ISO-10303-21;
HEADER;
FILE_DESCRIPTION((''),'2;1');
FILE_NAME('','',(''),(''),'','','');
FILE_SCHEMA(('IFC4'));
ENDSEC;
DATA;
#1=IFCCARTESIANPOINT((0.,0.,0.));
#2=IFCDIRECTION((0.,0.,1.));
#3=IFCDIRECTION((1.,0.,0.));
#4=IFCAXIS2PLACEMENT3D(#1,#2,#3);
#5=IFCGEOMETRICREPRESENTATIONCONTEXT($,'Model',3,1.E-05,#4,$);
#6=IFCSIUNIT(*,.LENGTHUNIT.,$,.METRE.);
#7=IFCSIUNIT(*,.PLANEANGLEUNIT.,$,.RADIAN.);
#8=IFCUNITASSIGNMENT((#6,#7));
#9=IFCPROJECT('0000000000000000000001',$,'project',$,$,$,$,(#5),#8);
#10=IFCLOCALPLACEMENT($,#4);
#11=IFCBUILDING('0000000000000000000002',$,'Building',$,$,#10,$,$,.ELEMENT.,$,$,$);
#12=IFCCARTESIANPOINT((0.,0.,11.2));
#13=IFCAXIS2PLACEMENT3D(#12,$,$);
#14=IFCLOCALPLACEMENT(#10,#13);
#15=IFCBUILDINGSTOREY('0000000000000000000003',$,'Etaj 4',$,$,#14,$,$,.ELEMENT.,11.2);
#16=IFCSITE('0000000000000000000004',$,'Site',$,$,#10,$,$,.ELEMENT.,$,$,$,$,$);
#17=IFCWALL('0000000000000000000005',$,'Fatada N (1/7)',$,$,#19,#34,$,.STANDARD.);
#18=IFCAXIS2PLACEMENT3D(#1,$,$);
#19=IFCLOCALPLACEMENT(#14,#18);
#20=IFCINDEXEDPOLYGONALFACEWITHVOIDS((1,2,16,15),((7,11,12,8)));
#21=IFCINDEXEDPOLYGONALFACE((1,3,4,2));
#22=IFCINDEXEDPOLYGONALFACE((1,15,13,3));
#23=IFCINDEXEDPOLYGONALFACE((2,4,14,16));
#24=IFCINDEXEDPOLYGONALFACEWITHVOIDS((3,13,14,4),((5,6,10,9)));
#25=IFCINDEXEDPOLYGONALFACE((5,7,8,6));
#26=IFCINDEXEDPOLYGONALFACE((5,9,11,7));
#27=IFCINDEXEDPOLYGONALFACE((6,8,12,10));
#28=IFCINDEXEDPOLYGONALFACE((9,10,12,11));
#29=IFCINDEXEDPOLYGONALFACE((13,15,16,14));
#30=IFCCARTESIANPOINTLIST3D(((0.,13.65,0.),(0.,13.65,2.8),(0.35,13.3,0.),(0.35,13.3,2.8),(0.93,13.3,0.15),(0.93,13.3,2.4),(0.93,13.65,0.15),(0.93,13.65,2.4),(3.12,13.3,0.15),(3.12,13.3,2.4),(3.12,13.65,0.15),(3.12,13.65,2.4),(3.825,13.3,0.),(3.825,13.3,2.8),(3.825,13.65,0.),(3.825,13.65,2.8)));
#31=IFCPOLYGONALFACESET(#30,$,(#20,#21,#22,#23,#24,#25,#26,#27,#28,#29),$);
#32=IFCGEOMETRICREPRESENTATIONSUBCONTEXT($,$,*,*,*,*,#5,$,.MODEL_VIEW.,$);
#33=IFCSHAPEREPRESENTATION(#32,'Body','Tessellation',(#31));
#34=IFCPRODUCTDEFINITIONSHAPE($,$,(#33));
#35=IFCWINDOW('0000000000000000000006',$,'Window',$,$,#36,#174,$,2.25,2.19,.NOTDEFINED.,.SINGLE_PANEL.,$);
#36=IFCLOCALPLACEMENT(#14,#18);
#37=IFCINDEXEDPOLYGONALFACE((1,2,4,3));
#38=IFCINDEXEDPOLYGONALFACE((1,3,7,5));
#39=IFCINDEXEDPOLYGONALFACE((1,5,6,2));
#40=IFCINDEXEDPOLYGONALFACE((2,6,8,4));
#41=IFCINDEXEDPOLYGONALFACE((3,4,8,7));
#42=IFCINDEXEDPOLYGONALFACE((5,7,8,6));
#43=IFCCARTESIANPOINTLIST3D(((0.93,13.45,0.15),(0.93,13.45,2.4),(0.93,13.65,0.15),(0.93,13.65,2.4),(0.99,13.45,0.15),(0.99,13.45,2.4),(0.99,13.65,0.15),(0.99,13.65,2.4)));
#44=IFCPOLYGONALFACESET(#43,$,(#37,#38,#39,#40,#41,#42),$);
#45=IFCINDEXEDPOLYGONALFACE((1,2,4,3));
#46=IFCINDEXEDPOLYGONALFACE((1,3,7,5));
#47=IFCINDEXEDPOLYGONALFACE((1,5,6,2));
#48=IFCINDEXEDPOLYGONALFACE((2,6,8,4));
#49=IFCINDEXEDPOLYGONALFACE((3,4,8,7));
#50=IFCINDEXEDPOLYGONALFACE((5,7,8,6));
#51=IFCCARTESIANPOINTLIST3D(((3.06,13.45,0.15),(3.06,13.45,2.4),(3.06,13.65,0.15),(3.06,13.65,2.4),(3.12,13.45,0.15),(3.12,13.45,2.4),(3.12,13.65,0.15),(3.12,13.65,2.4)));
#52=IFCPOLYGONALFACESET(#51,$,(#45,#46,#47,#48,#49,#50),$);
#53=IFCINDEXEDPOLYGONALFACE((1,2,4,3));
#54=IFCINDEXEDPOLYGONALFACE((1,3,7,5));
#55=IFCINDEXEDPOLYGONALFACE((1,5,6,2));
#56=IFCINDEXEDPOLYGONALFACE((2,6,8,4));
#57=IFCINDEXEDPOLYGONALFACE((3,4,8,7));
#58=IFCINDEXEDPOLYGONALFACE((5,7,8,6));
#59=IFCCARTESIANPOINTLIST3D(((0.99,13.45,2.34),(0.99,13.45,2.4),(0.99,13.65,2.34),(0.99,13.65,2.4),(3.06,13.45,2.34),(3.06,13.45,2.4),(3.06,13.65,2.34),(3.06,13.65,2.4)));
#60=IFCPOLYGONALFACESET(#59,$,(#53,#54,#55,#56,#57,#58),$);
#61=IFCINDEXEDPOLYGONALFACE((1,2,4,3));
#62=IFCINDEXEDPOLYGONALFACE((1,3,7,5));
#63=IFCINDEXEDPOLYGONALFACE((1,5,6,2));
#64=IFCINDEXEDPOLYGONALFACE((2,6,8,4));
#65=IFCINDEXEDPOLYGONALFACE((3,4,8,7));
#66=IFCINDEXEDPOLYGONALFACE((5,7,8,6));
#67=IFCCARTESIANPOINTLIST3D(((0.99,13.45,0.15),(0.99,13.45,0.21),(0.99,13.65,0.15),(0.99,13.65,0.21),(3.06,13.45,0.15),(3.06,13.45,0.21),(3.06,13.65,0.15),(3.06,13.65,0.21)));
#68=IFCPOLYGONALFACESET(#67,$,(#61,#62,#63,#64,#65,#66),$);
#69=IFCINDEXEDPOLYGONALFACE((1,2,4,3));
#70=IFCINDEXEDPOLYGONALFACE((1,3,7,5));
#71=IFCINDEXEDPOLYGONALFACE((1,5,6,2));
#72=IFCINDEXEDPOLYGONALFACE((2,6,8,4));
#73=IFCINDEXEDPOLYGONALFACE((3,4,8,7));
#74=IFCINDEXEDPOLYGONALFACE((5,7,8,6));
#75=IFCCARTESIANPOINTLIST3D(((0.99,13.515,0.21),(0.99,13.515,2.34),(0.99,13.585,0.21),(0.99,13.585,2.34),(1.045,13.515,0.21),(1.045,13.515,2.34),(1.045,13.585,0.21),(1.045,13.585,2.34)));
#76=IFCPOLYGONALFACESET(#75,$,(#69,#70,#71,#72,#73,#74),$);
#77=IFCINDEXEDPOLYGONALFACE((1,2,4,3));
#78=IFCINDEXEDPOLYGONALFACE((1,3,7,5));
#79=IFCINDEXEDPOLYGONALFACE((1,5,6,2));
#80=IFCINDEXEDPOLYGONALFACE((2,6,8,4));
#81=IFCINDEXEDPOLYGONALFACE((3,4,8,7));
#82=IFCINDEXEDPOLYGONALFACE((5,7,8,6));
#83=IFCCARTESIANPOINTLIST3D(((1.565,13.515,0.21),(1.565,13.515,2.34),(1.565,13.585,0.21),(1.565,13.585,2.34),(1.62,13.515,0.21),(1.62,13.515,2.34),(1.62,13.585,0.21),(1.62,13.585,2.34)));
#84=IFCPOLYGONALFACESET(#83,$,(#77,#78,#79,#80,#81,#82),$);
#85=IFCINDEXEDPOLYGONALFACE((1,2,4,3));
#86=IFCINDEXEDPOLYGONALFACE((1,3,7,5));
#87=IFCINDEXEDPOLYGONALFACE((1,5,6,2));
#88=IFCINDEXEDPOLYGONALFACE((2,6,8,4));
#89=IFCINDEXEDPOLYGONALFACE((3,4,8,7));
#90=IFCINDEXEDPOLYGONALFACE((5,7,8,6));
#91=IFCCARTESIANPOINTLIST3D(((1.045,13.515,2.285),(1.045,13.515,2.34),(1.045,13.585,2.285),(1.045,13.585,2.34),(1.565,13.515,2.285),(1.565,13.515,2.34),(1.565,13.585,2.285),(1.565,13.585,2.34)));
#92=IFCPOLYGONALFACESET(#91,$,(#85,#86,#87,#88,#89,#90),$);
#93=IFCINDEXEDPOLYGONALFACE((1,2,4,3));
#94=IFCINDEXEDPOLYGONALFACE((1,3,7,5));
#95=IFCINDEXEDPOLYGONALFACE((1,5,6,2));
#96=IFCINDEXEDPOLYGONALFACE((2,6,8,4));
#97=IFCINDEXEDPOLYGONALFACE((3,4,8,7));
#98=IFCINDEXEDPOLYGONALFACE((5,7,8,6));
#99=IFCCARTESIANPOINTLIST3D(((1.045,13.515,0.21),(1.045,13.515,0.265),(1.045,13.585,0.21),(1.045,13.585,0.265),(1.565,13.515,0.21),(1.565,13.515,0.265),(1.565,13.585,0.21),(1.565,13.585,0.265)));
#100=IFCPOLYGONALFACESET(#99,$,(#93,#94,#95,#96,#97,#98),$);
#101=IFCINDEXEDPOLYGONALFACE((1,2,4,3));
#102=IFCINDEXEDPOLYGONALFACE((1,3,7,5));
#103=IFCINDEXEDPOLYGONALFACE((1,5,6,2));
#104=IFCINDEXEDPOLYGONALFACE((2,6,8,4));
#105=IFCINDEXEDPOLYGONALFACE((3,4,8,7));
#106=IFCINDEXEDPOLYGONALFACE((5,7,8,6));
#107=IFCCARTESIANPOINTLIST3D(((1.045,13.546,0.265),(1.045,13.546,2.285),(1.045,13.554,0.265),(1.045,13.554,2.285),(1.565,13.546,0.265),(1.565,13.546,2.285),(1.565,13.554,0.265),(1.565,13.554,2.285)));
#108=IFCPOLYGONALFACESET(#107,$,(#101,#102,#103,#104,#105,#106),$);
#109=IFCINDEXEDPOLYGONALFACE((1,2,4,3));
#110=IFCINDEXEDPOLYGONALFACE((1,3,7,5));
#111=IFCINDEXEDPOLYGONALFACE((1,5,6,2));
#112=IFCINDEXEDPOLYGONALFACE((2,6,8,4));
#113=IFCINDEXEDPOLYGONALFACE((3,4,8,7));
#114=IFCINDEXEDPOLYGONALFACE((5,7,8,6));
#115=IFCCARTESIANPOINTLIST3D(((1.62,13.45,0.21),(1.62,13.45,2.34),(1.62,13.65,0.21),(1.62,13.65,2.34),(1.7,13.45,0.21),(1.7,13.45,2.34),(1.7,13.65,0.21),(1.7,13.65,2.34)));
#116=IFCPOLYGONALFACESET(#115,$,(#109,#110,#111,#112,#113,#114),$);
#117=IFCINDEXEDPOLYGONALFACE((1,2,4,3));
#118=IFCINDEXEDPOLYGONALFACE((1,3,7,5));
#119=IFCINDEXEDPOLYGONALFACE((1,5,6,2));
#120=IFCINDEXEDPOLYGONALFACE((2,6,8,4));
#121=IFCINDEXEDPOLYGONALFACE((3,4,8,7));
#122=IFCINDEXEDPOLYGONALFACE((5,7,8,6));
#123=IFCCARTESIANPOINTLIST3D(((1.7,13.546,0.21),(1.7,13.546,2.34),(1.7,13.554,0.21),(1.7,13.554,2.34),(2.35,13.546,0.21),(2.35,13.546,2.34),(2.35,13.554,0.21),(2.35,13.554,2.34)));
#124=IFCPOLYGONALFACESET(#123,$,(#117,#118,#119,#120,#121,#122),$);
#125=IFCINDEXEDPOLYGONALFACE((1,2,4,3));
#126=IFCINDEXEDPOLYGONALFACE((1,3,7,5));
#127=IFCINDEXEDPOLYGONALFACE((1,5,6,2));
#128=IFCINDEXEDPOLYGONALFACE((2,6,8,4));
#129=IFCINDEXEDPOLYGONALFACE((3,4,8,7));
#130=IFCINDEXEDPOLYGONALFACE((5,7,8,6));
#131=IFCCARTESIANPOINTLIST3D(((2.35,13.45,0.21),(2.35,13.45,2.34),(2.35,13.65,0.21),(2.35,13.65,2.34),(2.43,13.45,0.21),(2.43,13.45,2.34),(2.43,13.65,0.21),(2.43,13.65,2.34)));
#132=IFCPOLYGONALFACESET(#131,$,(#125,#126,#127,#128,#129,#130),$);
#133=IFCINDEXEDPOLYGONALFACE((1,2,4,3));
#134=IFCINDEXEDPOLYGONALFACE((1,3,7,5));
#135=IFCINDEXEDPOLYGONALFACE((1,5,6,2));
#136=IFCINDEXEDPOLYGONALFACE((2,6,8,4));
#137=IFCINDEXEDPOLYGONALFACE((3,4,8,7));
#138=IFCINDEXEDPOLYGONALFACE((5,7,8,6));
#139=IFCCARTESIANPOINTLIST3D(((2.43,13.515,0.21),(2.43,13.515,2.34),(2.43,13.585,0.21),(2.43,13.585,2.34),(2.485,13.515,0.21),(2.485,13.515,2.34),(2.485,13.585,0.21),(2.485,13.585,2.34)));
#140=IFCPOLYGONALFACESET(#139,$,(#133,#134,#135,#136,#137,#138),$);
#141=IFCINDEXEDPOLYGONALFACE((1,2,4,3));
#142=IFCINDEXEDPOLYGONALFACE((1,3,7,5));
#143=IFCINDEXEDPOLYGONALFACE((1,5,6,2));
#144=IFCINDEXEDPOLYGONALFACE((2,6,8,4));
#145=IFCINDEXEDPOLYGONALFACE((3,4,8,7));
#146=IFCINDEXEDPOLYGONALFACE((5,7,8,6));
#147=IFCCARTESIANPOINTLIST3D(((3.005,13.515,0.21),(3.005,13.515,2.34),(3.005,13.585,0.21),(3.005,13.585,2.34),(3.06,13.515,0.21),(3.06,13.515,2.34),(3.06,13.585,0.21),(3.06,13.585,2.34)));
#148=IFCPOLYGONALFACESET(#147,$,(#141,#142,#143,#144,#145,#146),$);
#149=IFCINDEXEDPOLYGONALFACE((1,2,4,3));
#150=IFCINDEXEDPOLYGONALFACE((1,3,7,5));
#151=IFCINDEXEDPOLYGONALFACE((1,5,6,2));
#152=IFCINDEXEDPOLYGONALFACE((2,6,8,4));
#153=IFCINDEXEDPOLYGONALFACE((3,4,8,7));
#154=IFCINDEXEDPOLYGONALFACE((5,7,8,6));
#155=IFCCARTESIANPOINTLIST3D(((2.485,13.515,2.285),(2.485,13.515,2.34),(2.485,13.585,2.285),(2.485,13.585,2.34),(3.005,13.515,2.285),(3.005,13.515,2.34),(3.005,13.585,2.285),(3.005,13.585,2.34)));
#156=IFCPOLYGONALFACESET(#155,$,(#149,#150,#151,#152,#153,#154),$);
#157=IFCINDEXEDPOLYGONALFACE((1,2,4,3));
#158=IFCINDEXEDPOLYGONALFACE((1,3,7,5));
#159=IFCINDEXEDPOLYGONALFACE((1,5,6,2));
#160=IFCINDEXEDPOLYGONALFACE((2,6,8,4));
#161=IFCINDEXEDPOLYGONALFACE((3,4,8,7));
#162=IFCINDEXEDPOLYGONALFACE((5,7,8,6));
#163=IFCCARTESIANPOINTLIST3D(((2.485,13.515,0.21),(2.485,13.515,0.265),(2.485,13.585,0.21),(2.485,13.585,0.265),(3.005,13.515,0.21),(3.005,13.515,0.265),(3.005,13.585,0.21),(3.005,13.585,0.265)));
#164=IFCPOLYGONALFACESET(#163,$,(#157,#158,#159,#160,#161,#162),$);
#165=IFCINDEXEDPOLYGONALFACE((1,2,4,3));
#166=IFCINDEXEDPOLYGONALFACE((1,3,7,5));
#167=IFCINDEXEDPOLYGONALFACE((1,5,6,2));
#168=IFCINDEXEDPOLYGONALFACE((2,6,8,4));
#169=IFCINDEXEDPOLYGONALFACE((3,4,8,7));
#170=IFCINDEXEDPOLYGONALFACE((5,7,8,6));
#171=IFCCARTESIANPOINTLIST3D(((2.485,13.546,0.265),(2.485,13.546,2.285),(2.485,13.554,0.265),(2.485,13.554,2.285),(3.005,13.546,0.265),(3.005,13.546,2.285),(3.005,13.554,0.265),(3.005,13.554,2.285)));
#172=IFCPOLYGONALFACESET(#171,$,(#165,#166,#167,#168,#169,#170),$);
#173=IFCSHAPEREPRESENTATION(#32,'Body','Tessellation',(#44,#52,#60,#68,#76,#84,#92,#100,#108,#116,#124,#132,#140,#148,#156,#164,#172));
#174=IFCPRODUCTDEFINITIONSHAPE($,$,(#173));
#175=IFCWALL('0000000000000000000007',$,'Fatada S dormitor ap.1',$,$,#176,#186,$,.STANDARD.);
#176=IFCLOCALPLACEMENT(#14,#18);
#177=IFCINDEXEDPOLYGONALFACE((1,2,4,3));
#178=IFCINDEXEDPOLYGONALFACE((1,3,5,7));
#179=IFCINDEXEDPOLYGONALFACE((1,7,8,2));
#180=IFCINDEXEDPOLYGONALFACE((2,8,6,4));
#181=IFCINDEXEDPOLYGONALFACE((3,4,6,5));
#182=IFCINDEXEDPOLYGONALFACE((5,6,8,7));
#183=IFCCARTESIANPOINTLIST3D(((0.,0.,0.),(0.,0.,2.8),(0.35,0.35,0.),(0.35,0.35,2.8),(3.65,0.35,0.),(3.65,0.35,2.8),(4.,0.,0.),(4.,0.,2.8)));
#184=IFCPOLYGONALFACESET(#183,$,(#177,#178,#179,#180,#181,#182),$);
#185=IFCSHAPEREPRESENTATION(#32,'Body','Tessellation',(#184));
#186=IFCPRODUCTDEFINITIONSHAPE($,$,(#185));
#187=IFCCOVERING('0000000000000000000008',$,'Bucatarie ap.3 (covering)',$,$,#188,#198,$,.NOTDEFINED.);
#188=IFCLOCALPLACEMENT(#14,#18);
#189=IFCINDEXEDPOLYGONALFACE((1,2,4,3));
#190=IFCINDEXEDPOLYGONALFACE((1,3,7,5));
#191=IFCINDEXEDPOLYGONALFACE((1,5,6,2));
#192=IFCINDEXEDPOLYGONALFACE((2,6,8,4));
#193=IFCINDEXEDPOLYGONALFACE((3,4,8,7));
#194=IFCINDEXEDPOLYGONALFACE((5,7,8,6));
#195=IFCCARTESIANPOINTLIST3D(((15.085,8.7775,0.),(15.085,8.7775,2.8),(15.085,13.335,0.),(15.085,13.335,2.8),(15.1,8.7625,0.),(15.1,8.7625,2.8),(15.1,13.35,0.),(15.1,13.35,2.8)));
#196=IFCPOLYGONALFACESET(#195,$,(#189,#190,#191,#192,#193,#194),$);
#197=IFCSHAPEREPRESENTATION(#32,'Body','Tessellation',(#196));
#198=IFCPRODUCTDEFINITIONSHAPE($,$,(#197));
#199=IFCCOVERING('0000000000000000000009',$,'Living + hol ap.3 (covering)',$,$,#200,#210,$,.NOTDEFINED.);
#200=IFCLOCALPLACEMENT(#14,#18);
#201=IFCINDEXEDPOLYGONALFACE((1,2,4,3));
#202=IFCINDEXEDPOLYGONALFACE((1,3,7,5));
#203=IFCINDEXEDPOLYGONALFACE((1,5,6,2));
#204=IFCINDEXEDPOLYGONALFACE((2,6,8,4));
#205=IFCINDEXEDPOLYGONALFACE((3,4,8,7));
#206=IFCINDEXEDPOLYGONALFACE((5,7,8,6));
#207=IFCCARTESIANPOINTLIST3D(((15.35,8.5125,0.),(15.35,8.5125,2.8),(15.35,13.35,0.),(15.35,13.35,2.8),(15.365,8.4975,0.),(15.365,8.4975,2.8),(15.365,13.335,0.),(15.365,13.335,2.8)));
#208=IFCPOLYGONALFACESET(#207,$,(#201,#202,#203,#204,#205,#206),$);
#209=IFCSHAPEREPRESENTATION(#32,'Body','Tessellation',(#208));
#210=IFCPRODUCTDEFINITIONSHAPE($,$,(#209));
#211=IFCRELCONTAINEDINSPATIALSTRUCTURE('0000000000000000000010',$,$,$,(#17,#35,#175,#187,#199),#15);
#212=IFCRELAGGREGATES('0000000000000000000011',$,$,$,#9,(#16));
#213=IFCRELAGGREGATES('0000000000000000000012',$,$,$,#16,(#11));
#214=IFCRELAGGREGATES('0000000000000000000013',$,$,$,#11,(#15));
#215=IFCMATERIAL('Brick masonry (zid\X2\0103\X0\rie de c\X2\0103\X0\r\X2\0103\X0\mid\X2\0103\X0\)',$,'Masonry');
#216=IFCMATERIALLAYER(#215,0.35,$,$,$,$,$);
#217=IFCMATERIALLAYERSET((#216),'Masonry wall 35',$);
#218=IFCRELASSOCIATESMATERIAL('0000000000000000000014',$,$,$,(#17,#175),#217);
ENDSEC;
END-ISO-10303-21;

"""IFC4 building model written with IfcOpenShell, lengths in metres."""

from ifc_helpers import new_model, si_unit, frame, frame_2d, origin, origin_with_axes, origin_2d, place, context, subcontext, project, spatial, polyline, rectangle, outline, extrude, clip, halfspace, material, layer, layer_set, layer_usage, element, fill, save


model = new_model("IFC4")

# Units and contexts
model_context = context("Model", 3, precision=1e-05, world=origin_with_axes())
sub_context = subcontext(model_context, None, None, "MODEL_VIEW")
ifc_project = project(units=[si_unit("LENGTHUNIT", "METRE"), si_unit("PLANEANGLEUNIT", "RADIAN")], contexts=[model_context])

# Site, building, storey
placement = place(None, origin_with_axes())
site = spatial("IfcSite", under=ifc_project, at=placement, Name="Site", CompositionType="ELEMENT")
building = spatial("IfcBuilding", under=site, at=placement, Name="Building", CompositionType="ELEMENT")
storey_placement = place(placement, frame((0.0, 0.0, 11.2)))
storey = spatial("IfcBuildingStorey", under=building, at=storey_placement, Name="Etaj 4", CompositionType="ELEMENT", Elevation=11.2)

# Wall, opening, window
ifc_material = material(Name="Brick masonry (zidărie de cărămidă)", Category="Masonry")
ifc_layer = layer(ifc_material, 0.35)
ifc_layer_set = layer_set([ifc_layer], Name="Masonry wall 35")
ifc_layer_usage = layer_usage(ifc_layer_set, "AXIS2", "POSITIVE", -0.175)
wall_1_placement = place(storey_placement, frame((0.0, 13.475, 0.0), x_axis=(1.0, 0.0, 0.0)))
wall_1 = element("IfcWall", 1, at=wall_1_placement, inside=storey, material=ifc_layer_usage, Name="Fatada N (1/7)", PredefinedType="STANDARD", context=sub_context, shape_type="CSG", body=[
    clip(extrude(rectangle(XDim=3.825, YDim=0.35, at=frame_2d((1.9125, 0.0))), origin(), (0.0, 0.0, 1.0), 2.8), halfspace(frame((0.175, 0.0, 0.0), z_axis=(-0.707107, -0.707107, 0.0)), False)),
])
opening_1_placement = place(wall_1_placement, frame((2.025, 0.225, 0.15), z_axis=(0.0, -1.0, 0.0), x_axis=(1.0, 0.0, 0.0)))
opening_1 = element("IfcOpeningElement", 2, at=opening_1_placement, cuts=wall_1, PredefinedType="OPENING", context=sub_context, shape_type="SweptSolid", body=[
    extrude(rectangle(XDim=2.19, YDim=2.25, at=frame_2d((0.0, 1.125))), origin(), (0.0, 0.0, 1.0), 0.45),
])
window_placement = place(wall_1_placement, frame((2.025, 0.175, 0.15), z_axis=(0.0, -1.0, 0.0), x_axis=(1.0, 0.0, 0.0)))
window = element("IfcWindow", 3, at=window_placement, inside=storey, Name="Window", OverallHeight=2.25, OverallWidth=2.19, PartitioningType="SINGLE_PANEL", PredefinedType="NOTDEFINED", context=sub_context, shape_type="SweptSolid", body=[
    extrude(rectangle(XDim=0.06, YDim=2.25, at=origin_2d()), frame((-1.065, 1.125, 0.0)), (0.0, 0.0, 1.0), 0.2),
    extrude(rectangle(XDim=0.06, YDim=2.25, at=origin_2d()), frame((1.065, 1.125, 0.0)), (0.0, 0.0, 1.0), 0.2),
    extrude(rectangle(XDim=2.07, YDim=0.06, at=origin_2d()), frame((0.0, 2.22, 0.0)), (0.0, 0.0, 1.0), 0.2),
    extrude(rectangle(XDim=2.07, YDim=0.06, at=origin_2d()), frame((0.0, 0.03, 0.0)), (0.0, 0.0, 1.0), 0.2),
    extrude(rectangle(XDim=0.055, YDim=2.13, at=origin_2d()), frame((-1.0075, 1.125, 0.065)), (0.0, 0.0, 1.0), 0.07),
    extrude(rectangle(XDim=0.055, YDim=2.13, at=origin_2d()), frame((-0.4325, 1.125, 0.065)), (0.0, 0.0, 1.0), 0.07),
    extrude(rectangle(XDim=0.52, YDim=0.055, at=origin_2d()), frame((-0.72, 2.1625, 0.065)), (0.0, 0.0, 1.0), 0.07),
    extrude(rectangle(XDim=0.52, YDim=0.055, at=origin_2d()), frame((-0.72, 0.0875, 0.065)), (0.0, 0.0, 1.0), 0.07),
    extrude(rectangle(XDim=0.52, YDim=2.02, at=origin_2d()), frame((-0.72, 1.125, 0.096)), (0.0, 0.0, 1.0), 0.008),
    extrude(rectangle(XDim=0.08, YDim=2.13, at=origin_2d()), frame((-0.365, 1.125, 0.0)), (0.0, 0.0, 1.0), 0.2),
    extrude(rectangle(XDim=0.65, YDim=2.13, at=origin_2d()), frame((0.0, 1.125, 0.096)), (0.0, 0.0, 1.0), 0.008),
    extrude(rectangle(XDim=0.08, YDim=2.13, at=origin_2d()), frame((0.365, 1.125, 0.0)), (0.0, 0.0, 1.0), 0.2),
    extrude(rectangle(XDim=0.055, YDim=2.13, at=origin_2d()), frame((0.4325, 1.125, 0.065)), (0.0, 0.0, 1.0), 0.07),
    extrude(rectangle(XDim=0.055, YDim=2.13, at=origin_2d()), frame((1.0075, 1.125, 0.065)), (0.0, 0.0, 1.0), 0.07),
    extrude(rectangle(XDim=0.52, YDim=0.055, at=origin_2d()), frame((0.72, 2.1625, 0.065)), (0.0, 0.0, 1.0), 0.07),
    extrude(rectangle(XDim=0.52, YDim=0.055, at=origin_2d()), frame((0.72, 0.0875, 0.065)), (0.0, 0.0, 1.0), 0.07),
    extrude(rectangle(XDim=0.52, YDim=2.02, at=origin_2d()), frame((0.72, 1.125, 0.096)), (0.0, 0.0, 1.0), 0.008),
])
fill(opening_1, window)

# Wall
wall_2_placement = place(storey_placement, frame((0.0, 0.175, 0.0), x_axis=(1.0, 0.0, 0.0)))
element("IfcWall", 4, at=wall_2_placement, inside=storey, material=ifc_layer_usage, Name="Fatada S dormitor ap.1", PredefinedType="STANDARD", context=sub_context, shape_type="CSG", body=[
    clip(clip(extrude(rectangle(XDim=4.0, YDim=0.35, at=frame_2d((2.0, 0.0))), origin(), (0.0, 0.0, 1.0), 2.8), halfspace(frame((0.175, 0.0, 0.0), z_axis=(-0.707107, 0.707107, 0.0)), False)), halfspace(frame((3.825, 0.0, 0.0), z_axis=(0.707107, 0.707107, 0.0)), False)),
])

# Coverings
covering_1_placement = place(storey_placement, origin_with_axes())
element("IfcCovering", 5, at=covering_1_placement, inside=storey, Name="Bucatarie ap.3 (covering)", PredefinedType="NOTDEFINED", context=sub_context, shape_type="SweptSolid", body=[
    extrude(outline(polyline([(15.1, 8.7625), (15.1, 13.35), (15.085, 13.335), (15.085, 8.7775), (15.1, 8.7625)])), origin(), (0.0, 0.0, 1.0), 2.8),
])
covering_2_placement = place(storey_placement, origin_with_axes())
element("IfcCovering", 6, at=covering_2_placement, inside=storey, Name="Living + hol ap.3 (covering)", PredefinedType="NOTDEFINED", context=sub_context, shape_type="SweptSolid", body=[
    extrude(outline(polyline([(15.35, 13.35), (15.35, 8.5125), (15.365, 8.4975), (15.365, 13.335), (15.35, 13.35)])), origin(), (0.0, 0.0, 1.0), 2.8),
])

save(model, "model.ifc")
